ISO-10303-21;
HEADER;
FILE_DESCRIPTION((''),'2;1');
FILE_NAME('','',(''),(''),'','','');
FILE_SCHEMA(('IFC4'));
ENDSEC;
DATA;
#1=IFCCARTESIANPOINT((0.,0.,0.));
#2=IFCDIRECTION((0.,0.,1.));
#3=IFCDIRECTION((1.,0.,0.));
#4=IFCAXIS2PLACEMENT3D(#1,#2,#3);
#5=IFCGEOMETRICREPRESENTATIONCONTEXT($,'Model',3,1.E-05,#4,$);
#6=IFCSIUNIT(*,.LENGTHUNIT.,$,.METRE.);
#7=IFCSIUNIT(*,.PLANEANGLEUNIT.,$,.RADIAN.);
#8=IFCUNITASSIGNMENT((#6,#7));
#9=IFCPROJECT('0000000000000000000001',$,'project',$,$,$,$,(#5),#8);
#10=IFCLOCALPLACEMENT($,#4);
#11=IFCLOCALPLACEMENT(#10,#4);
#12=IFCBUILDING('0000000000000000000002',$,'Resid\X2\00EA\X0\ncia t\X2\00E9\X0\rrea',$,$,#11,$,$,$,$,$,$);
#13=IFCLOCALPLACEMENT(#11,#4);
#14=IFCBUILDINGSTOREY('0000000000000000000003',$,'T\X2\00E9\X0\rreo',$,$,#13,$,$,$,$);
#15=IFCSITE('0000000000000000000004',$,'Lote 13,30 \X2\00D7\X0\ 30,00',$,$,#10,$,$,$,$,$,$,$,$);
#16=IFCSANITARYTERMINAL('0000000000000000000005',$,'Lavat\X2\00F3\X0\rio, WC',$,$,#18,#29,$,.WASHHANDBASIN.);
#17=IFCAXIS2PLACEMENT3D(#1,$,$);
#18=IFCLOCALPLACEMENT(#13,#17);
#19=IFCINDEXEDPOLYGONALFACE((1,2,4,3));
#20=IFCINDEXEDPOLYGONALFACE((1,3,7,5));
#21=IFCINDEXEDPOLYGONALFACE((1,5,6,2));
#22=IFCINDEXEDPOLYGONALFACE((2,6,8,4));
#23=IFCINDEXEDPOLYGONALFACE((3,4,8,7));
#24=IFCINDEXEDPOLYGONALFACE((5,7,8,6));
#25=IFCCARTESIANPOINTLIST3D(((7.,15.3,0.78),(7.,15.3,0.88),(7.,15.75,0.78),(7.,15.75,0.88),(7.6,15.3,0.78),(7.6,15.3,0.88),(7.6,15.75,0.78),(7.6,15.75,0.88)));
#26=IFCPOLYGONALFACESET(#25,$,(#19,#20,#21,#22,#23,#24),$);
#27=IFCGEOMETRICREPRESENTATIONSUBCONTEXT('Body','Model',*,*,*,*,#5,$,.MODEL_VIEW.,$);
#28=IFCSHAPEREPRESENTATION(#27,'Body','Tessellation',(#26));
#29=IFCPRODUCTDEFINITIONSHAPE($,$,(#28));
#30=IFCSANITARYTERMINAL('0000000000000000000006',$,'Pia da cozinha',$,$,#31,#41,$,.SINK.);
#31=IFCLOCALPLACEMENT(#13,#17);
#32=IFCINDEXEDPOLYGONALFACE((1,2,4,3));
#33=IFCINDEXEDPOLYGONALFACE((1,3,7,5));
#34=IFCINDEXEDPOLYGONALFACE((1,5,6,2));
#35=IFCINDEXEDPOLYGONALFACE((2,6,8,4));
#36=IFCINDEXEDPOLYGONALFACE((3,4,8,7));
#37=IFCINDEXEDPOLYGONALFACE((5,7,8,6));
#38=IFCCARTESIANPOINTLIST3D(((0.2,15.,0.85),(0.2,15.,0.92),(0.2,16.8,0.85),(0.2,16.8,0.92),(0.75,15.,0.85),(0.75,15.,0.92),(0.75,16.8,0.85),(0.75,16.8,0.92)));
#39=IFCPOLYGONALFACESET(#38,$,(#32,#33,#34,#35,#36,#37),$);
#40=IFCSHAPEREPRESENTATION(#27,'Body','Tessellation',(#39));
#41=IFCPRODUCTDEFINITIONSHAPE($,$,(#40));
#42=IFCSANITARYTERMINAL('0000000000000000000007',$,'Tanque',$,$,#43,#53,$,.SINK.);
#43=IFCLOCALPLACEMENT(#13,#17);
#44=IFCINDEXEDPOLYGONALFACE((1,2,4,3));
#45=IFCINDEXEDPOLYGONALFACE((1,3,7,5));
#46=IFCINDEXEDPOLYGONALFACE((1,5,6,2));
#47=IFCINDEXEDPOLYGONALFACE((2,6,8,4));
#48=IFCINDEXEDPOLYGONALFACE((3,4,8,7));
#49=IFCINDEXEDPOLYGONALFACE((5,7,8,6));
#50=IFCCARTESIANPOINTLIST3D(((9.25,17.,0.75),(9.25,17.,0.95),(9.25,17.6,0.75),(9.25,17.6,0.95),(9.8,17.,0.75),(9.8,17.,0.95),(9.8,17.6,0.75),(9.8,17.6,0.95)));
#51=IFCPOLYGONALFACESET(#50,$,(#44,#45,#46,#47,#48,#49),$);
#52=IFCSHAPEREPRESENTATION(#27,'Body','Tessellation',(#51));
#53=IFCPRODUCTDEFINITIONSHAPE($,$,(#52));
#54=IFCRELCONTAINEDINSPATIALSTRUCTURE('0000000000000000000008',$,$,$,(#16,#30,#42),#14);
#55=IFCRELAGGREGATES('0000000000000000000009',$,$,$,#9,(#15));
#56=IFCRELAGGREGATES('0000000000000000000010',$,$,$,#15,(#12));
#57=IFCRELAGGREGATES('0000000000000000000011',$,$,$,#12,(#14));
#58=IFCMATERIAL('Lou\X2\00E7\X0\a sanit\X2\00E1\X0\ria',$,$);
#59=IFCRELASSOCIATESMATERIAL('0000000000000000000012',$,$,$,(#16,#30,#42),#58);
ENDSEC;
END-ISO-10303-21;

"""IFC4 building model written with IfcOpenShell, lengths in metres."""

from ifc_helpers import new_model, si_unit, frame, origin_with_axes, place, context, subcontext, project, spatial, line, indexed_curve, outline, extrude, material, element, save


model = new_model("IFC4")

# Units and contexts
model_context = context("Model", 3, precision=1e-05, world=origin_with_axes())
body_context = subcontext(model_context, "Body", "Model", "MODEL_VIEW")
ifc_project = project(units=[si_unit("LENGTHUNIT", "METRE"), si_unit("PLANEANGLEUNIT", "RADIAN")], contexts=[model_context])

# Site, building, storey
site_placement = place(None, origin_with_axes())
site = spatial("IfcSite", under=ifc_project, at=site_placement, Name="Lote 13,30 × 30,00")
building_placement = place(site_placement, origin_with_axes())
building = spatial("IfcBuilding", under=site, at=building_placement, Name="Residência térrea")
storey_placement = place(building_placement, origin_with_axes())
storey = spatial("IfcBuildingStorey", under=building, at=storey_placement, Name="Térreo")

# Sanitary terminals
ifc_material_1 = material(Name="Louça sanitária")
sanitary_terminal_1_placement = place(storey_placement, frame((7.0, 15.3, 0.78), z_axis=(0.0, 0.0, 1.0), x_axis=(1.0, 0.0, 0.0)))
element("IfcSanitaryTerminal", 1, at=sanitary_terminal_1_placement, inside=storey, material=ifc_material_1, Name="Lavatório, WC", PredefinedType="WASHHANDBASIN", context=body_context, shape_type="SweptSolid", body=[
    extrude(outline(indexed_curve([(0.0, 0.0), (0.6, 0.0), (0.6, 0.45), (0.0, 0.45)], segments=[line(1, 2, 3, 4, 1)])), origin_with_axes(), (0.0, 0.0, 1.0), 0.1),
])
sanitary_terminal_2_placement = place(storey_placement, frame((0.2, 15.0, 0.85), z_axis=(0.0, 0.0, 1.0), x_axis=(1.0, 0.0, 0.0)))
element("IfcSanitaryTerminal", 2, at=sanitary_terminal_2_placement, inside=storey, material=ifc_material_1, Name="Pia da cozinha", PredefinedType="SINK", context=body_context, shape_type="SweptSolid", body=[
    extrude(outline(indexed_curve([(0.0, 0.0), (0.55, 0.0), (0.55, 1.8), (0.0, 1.8)], segments=[line(1, 2, 3, 4, 1)])), origin_with_axes(), (0.0, 0.0, 1.0), 0.07),
])
sanitary_terminal_3_placement = place(storey_placement, frame((9.25, 17.0, 0.75), z_axis=(0.0, 0.0, 1.0), x_axis=(1.0, 0.0, 0.0)))
element("IfcSanitaryTerminal", 3, at=sanitary_terminal_3_placement, inside=storey, material=ifc_material_1, Name="Tanque", PredefinedType="SINK", context=body_context, shape_type="SweptSolid", body=[
    extrude(outline(indexed_curve([(0.0, 0.0), (0.55, 0.0), (0.55, 0.6), (0.0, 0.6)], segments=[line(1, 2, 3, 4, 1)])), origin_with_axes(), (0.0, 0.0, 1.0), 0.2),
])

save(model, "model.ifc")
